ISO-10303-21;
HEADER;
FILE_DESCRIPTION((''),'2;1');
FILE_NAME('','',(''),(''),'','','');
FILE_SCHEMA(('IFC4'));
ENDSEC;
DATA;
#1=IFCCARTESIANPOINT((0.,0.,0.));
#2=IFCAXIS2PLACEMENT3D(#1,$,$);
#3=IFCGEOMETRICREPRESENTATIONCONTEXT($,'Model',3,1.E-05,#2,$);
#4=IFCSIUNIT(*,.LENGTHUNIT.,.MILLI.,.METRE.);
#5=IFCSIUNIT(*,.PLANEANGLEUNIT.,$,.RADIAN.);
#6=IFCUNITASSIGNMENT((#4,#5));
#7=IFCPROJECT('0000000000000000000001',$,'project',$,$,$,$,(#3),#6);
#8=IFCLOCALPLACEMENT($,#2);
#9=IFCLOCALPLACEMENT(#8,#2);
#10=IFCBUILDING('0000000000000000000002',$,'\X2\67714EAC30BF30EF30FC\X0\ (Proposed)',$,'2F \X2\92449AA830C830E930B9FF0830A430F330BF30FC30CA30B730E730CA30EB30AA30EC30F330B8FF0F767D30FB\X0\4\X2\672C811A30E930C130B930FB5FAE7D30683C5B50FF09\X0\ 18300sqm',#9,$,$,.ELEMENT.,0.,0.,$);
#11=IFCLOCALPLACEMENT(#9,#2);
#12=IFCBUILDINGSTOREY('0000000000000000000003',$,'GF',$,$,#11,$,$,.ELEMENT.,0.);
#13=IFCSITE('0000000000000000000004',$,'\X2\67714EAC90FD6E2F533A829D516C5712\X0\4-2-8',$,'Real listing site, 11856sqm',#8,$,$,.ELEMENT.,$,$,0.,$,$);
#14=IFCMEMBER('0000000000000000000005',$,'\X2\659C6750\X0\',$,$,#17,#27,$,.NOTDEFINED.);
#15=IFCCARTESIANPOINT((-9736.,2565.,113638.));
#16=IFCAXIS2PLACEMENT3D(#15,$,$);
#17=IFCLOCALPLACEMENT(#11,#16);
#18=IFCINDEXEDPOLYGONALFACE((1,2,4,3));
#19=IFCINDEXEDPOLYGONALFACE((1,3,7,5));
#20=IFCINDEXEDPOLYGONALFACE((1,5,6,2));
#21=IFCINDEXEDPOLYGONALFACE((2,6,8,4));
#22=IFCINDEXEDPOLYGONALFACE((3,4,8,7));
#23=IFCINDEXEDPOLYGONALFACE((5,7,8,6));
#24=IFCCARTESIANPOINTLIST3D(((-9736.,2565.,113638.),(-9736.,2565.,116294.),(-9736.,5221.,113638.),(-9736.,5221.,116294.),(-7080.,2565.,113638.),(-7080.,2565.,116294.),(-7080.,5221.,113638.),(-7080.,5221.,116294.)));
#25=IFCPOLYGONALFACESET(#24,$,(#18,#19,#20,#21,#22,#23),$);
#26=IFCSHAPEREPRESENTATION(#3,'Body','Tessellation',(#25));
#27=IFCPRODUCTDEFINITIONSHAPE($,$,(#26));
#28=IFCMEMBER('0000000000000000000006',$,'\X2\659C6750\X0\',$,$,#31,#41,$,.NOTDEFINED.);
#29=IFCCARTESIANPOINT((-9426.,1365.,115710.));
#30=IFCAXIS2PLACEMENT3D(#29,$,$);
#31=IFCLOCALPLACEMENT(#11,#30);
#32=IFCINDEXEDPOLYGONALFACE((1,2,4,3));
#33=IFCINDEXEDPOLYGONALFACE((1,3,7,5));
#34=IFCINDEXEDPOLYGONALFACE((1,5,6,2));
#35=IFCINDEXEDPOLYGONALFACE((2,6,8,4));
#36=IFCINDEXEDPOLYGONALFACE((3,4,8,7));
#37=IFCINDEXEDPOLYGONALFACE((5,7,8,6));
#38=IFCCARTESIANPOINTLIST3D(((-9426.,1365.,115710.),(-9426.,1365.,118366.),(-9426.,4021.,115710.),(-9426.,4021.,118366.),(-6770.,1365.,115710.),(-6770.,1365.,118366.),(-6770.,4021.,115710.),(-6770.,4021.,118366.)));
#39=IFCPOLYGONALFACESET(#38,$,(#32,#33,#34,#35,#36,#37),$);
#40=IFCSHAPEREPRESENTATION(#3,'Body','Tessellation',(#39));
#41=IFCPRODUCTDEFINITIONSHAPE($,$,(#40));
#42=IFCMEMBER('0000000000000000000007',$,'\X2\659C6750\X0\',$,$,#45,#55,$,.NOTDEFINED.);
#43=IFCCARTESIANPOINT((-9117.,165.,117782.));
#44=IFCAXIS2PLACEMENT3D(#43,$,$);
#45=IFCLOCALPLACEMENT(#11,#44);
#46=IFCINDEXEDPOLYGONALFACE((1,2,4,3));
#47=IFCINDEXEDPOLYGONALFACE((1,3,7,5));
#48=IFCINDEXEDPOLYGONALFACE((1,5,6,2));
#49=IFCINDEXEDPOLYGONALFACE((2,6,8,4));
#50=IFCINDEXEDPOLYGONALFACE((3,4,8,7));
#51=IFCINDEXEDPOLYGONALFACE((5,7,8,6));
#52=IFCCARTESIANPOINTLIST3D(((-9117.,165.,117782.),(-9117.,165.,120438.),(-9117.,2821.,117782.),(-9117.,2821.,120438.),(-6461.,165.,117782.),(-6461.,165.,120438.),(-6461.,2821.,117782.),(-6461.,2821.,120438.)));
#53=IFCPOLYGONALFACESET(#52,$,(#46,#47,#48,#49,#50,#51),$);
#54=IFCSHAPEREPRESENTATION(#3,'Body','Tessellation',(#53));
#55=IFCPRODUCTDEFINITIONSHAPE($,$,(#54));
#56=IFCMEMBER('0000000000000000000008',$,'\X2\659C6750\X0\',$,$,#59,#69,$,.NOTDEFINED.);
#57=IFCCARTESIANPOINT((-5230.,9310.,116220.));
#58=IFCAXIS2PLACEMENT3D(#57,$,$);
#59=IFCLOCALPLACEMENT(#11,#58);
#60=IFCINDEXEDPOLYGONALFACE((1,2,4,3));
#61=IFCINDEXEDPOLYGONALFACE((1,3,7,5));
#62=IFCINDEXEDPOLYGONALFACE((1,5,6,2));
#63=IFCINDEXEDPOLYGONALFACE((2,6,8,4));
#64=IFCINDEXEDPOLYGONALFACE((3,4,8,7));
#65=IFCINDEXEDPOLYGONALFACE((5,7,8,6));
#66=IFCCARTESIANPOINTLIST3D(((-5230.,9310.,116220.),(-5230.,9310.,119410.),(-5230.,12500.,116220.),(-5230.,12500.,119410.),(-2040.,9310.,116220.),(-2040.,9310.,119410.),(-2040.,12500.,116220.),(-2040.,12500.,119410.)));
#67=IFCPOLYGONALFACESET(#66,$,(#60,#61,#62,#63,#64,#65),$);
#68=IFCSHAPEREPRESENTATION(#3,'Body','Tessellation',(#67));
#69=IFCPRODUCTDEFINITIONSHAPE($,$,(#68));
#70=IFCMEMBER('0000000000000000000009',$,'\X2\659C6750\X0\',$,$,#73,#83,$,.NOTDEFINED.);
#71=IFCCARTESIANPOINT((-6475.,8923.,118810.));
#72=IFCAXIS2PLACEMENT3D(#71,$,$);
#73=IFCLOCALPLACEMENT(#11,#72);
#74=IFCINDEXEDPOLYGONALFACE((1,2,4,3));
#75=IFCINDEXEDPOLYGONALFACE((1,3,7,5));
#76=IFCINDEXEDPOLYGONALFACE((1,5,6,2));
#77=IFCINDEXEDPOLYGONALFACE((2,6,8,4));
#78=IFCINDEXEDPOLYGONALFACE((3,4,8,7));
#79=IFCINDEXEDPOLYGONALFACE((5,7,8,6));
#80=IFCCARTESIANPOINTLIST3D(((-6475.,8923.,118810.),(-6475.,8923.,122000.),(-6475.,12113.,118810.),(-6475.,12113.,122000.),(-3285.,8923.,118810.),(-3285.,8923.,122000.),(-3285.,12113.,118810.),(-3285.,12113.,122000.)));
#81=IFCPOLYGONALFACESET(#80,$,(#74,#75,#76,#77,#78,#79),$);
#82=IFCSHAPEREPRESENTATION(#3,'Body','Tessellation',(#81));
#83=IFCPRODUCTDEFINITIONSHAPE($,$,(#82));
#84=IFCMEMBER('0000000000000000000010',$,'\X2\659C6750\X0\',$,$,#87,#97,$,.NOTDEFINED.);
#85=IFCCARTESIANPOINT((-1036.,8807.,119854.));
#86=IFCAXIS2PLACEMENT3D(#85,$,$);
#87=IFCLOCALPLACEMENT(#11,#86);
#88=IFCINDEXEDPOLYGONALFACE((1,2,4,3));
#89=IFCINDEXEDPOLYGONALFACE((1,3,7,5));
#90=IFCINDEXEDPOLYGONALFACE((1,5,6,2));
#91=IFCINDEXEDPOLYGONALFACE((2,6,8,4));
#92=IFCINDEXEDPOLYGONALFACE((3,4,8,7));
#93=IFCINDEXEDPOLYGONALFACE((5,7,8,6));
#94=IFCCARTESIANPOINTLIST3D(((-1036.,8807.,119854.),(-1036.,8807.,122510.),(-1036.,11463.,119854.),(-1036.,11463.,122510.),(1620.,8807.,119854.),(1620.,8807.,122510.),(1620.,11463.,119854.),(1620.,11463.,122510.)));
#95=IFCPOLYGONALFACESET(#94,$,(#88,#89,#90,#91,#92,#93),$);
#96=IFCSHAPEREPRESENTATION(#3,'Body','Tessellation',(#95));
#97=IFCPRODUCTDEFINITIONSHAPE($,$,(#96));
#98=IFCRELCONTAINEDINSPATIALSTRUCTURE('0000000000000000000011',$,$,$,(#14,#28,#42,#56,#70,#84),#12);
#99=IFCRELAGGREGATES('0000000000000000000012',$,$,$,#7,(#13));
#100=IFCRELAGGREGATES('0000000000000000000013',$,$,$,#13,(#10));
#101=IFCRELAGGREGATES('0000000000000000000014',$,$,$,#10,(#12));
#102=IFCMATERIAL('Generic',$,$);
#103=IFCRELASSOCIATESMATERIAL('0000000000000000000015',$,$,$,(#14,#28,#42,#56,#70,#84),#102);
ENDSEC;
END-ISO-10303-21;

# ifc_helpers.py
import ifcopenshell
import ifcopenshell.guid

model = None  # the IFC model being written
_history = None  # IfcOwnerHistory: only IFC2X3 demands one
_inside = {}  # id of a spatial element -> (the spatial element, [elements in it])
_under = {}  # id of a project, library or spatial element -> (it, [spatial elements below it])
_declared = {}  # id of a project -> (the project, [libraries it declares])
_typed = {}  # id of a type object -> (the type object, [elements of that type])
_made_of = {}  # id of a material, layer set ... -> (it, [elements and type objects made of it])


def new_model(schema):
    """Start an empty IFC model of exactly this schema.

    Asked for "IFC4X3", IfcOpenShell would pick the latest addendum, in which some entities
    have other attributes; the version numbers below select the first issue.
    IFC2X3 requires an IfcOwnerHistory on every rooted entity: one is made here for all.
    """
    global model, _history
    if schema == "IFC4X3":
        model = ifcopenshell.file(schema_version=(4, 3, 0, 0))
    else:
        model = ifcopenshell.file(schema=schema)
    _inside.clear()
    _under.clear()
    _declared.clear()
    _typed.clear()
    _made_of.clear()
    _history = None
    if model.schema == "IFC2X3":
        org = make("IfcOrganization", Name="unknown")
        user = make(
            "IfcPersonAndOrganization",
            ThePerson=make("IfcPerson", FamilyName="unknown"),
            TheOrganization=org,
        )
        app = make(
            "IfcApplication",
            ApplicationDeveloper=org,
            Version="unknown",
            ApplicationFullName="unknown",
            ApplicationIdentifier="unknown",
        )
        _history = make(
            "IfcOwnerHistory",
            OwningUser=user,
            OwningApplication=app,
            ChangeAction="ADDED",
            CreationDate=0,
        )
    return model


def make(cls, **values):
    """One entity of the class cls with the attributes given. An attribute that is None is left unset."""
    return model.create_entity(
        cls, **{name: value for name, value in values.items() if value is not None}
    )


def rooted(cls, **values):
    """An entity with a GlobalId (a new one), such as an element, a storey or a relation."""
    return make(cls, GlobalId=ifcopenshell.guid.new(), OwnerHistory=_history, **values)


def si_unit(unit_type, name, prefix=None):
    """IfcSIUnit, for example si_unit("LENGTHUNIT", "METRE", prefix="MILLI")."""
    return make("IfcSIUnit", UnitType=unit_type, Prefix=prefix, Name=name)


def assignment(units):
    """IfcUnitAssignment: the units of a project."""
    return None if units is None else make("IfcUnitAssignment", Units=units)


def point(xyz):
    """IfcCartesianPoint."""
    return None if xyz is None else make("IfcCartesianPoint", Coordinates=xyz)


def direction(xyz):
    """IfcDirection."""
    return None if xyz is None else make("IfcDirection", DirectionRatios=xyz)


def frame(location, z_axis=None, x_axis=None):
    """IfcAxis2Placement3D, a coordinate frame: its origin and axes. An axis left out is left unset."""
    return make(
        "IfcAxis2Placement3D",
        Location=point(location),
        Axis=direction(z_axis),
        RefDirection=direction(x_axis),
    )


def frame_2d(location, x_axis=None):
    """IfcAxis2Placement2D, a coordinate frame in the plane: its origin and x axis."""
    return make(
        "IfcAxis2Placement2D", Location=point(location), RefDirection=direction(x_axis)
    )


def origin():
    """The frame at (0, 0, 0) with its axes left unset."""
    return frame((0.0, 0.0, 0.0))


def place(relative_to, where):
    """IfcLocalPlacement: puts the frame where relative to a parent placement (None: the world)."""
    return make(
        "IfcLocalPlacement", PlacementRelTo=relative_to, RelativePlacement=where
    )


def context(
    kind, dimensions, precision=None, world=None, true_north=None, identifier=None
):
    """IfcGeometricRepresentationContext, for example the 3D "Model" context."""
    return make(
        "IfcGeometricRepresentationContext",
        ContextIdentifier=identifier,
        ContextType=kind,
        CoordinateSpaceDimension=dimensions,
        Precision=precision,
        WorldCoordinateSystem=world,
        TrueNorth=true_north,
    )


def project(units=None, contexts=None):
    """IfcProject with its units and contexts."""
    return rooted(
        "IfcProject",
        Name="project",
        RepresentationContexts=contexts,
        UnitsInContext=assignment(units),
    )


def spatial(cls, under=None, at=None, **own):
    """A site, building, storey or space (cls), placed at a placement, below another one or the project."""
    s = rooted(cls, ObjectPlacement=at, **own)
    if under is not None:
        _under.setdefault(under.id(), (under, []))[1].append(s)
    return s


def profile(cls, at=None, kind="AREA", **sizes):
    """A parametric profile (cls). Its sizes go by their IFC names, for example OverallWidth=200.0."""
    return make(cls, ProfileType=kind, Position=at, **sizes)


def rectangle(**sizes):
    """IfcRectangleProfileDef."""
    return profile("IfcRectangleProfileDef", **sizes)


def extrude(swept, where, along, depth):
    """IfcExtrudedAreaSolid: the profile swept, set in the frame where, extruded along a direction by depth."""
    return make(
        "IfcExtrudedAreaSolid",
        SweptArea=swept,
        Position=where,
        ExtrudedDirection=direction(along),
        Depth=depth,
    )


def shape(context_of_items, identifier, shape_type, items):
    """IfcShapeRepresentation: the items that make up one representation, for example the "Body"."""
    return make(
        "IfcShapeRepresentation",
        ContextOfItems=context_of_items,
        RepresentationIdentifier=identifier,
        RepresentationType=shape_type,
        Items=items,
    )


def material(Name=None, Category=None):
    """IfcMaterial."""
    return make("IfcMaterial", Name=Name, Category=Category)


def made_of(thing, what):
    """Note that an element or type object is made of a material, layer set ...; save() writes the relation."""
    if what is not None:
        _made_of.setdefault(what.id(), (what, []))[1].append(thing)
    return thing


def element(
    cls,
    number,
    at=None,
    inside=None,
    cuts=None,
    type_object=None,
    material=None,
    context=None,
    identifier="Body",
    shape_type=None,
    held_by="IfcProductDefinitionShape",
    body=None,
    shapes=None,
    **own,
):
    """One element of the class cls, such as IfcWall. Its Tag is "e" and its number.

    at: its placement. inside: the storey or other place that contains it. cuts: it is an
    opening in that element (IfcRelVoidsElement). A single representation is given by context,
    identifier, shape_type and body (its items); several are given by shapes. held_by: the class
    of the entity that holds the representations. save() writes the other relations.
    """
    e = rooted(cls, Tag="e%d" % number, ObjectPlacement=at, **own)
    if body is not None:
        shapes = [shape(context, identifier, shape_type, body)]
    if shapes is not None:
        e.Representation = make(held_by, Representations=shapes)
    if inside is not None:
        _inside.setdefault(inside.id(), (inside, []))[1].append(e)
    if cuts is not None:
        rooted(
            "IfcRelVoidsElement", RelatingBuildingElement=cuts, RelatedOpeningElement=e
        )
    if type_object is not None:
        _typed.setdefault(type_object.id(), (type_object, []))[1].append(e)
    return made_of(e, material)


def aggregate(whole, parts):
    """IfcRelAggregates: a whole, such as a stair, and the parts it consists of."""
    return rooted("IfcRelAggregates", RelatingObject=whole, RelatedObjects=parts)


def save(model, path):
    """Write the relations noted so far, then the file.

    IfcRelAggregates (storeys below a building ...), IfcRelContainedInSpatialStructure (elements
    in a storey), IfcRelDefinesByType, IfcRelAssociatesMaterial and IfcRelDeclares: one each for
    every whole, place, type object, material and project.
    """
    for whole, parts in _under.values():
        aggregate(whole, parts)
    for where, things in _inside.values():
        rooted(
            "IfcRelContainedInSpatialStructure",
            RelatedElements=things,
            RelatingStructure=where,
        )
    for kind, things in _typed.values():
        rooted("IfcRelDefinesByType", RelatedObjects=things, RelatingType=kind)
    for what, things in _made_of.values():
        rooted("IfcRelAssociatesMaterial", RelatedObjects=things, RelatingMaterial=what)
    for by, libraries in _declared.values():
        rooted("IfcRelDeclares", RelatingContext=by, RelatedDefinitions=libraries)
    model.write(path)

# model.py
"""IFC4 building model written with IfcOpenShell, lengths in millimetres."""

from ifc_helpers import new_model, si_unit, frame, frame_2d, origin, place, context, project, spatial, rectangle, extrude, material, element, save


model = new_model("IFC4")

# Units and contexts
model_context = context("Model", 3, precision=1e-05, world=origin())
ifc_project = project(units=[si_unit("LENGTHUNIT", "METRE", prefix="MILLI"), si_unit("PLANEANGLEUNIT", "RADIAN")], contexts=[model_context])

# Site, building, storey
site_placement = place(None, origin())
site = spatial("IfcSite", under=ifc_project, at=site_placement, Name="東京都港区芝公園4-2-8", ObjectType="Real listing site, 11856sqm", CompositionType="ELEMENT", RefElevation=0.0)
building_placement = place(site_placement, origin())
building = spatial("IfcBuilding", under=site, at=building_placement, Name="東京タワー (Proposed)", ObjectType="2F 鉄骨トラス（インターナショナルオレンジ／白・4本脚ラチス・微細格子） 18300sqm", CompositionType="ELEMENT", ElevationOfRefHeight=0.0, ElevationOfTerrain=0.0)
storey_placement = place(building_placement, origin())
storey = spatial("IfcBuildingStorey", under=building, at=storey_placement, Name="GF", CompositionType="ELEMENT", Elevation=0.0)

# Shared definitions
ifc_material = material(Name="Generic")

# Members
member_1_placement = place(storey_placement, frame((-9736.0, 2565.0, 113638.0)))
element("IfcMember", 1, at=member_1_placement, inside=storey, material=ifc_material, Name="斜材", PredefinedType="NOTDEFINED", context=model_context, shape_type="SweptSolid", body=[
    extrude(rectangle(XDim=2656.0, YDim=2656.0, at=frame_2d((1328.0, 1328.0))), frame((-9736.0, 2565.0, 113638.0)), (0.0, 0.0, 1.0), 2656.0),
])
member_2_placement = place(storey_placement, frame((-9426.0, 1365.0, 115710.0)))
element("IfcMember", 2, at=member_2_placement, inside=storey, material=ifc_material, Name="斜材", PredefinedType="NOTDEFINED", context=model_context, shape_type="SweptSolid", body=[
    extrude(rectangle(XDim=2656.0, YDim=2656.0, at=frame_2d((1328.0, 1328.0))), frame((-9426.0, 1365.0, 115710.0)), (0.0, 0.0, 1.0), 2656.0),
])
member_3_placement = place(storey_placement, frame((-9117.0, 165.0, 117782.0)))
element("IfcMember", 3, at=member_3_placement, inside=storey, material=ifc_material, Name="斜材", PredefinedType="NOTDEFINED", context=model_context, shape_type="SweptSolid", body=[
    extrude(rectangle(XDim=2656.0, YDim=2656.0, at=frame_2d((1328.0, 1328.0))), frame((-9117.0, 165.0, 117782.0)), (0.0, 0.0, 1.0), 2656.0),
])
member_4_placement = place(storey_placement, frame((-5230.0, 9310.0, 116220.0)))
element("IfcMember", 4, at=member_4_placement, inside=storey, material=ifc_material, Name="斜材", PredefinedType="NOTDEFINED", context=model_context, shape_type="SweptSolid", body=[
    extrude(rectangle(XDim=3190.0, YDim=3190.0, at=frame_2d((1595.0, 1595.0))), frame((-5230.0, 9310.0, 116220.0)), (0.0, 0.0, 1.0), 3190.0),
])
member_5_placement = place(storey_placement, frame((-6475.0, 8923.0, 118810.0)))
element("IfcMember", 5, at=member_5_placement, inside=storey, material=ifc_material, Name="斜材", PredefinedType="NOTDEFINED", context=model_context, shape_type="SweptSolid", body=[
    extrude(rectangle(XDim=3190.0, YDim=3190.0, at=frame_2d((1595.0, 1595.0))), frame((-6475.0, 8923.0, 118810.0)), (0.0, 0.0, 1.0), 3190.0),
])
member_6_placement = place(storey_placement, frame((-1036.0, 8807.0, 119854.0)))
element("IfcMember", 6, at=member_6_placement, inside=storey, material=ifc_material, Name="斜材", PredefinedType="NOTDEFINED", context=model_context, shape_type="SweptSolid", body=[
    extrude(rectangle(XDim=2656.0, YDim=2656.0, at=frame_2d((1328.0, 1328.0))), frame((-1036.0, 8807.0, 119854.0)), (0.0, 0.0, 1.0), 2656.0),
])

save(model, "model.ifc")
